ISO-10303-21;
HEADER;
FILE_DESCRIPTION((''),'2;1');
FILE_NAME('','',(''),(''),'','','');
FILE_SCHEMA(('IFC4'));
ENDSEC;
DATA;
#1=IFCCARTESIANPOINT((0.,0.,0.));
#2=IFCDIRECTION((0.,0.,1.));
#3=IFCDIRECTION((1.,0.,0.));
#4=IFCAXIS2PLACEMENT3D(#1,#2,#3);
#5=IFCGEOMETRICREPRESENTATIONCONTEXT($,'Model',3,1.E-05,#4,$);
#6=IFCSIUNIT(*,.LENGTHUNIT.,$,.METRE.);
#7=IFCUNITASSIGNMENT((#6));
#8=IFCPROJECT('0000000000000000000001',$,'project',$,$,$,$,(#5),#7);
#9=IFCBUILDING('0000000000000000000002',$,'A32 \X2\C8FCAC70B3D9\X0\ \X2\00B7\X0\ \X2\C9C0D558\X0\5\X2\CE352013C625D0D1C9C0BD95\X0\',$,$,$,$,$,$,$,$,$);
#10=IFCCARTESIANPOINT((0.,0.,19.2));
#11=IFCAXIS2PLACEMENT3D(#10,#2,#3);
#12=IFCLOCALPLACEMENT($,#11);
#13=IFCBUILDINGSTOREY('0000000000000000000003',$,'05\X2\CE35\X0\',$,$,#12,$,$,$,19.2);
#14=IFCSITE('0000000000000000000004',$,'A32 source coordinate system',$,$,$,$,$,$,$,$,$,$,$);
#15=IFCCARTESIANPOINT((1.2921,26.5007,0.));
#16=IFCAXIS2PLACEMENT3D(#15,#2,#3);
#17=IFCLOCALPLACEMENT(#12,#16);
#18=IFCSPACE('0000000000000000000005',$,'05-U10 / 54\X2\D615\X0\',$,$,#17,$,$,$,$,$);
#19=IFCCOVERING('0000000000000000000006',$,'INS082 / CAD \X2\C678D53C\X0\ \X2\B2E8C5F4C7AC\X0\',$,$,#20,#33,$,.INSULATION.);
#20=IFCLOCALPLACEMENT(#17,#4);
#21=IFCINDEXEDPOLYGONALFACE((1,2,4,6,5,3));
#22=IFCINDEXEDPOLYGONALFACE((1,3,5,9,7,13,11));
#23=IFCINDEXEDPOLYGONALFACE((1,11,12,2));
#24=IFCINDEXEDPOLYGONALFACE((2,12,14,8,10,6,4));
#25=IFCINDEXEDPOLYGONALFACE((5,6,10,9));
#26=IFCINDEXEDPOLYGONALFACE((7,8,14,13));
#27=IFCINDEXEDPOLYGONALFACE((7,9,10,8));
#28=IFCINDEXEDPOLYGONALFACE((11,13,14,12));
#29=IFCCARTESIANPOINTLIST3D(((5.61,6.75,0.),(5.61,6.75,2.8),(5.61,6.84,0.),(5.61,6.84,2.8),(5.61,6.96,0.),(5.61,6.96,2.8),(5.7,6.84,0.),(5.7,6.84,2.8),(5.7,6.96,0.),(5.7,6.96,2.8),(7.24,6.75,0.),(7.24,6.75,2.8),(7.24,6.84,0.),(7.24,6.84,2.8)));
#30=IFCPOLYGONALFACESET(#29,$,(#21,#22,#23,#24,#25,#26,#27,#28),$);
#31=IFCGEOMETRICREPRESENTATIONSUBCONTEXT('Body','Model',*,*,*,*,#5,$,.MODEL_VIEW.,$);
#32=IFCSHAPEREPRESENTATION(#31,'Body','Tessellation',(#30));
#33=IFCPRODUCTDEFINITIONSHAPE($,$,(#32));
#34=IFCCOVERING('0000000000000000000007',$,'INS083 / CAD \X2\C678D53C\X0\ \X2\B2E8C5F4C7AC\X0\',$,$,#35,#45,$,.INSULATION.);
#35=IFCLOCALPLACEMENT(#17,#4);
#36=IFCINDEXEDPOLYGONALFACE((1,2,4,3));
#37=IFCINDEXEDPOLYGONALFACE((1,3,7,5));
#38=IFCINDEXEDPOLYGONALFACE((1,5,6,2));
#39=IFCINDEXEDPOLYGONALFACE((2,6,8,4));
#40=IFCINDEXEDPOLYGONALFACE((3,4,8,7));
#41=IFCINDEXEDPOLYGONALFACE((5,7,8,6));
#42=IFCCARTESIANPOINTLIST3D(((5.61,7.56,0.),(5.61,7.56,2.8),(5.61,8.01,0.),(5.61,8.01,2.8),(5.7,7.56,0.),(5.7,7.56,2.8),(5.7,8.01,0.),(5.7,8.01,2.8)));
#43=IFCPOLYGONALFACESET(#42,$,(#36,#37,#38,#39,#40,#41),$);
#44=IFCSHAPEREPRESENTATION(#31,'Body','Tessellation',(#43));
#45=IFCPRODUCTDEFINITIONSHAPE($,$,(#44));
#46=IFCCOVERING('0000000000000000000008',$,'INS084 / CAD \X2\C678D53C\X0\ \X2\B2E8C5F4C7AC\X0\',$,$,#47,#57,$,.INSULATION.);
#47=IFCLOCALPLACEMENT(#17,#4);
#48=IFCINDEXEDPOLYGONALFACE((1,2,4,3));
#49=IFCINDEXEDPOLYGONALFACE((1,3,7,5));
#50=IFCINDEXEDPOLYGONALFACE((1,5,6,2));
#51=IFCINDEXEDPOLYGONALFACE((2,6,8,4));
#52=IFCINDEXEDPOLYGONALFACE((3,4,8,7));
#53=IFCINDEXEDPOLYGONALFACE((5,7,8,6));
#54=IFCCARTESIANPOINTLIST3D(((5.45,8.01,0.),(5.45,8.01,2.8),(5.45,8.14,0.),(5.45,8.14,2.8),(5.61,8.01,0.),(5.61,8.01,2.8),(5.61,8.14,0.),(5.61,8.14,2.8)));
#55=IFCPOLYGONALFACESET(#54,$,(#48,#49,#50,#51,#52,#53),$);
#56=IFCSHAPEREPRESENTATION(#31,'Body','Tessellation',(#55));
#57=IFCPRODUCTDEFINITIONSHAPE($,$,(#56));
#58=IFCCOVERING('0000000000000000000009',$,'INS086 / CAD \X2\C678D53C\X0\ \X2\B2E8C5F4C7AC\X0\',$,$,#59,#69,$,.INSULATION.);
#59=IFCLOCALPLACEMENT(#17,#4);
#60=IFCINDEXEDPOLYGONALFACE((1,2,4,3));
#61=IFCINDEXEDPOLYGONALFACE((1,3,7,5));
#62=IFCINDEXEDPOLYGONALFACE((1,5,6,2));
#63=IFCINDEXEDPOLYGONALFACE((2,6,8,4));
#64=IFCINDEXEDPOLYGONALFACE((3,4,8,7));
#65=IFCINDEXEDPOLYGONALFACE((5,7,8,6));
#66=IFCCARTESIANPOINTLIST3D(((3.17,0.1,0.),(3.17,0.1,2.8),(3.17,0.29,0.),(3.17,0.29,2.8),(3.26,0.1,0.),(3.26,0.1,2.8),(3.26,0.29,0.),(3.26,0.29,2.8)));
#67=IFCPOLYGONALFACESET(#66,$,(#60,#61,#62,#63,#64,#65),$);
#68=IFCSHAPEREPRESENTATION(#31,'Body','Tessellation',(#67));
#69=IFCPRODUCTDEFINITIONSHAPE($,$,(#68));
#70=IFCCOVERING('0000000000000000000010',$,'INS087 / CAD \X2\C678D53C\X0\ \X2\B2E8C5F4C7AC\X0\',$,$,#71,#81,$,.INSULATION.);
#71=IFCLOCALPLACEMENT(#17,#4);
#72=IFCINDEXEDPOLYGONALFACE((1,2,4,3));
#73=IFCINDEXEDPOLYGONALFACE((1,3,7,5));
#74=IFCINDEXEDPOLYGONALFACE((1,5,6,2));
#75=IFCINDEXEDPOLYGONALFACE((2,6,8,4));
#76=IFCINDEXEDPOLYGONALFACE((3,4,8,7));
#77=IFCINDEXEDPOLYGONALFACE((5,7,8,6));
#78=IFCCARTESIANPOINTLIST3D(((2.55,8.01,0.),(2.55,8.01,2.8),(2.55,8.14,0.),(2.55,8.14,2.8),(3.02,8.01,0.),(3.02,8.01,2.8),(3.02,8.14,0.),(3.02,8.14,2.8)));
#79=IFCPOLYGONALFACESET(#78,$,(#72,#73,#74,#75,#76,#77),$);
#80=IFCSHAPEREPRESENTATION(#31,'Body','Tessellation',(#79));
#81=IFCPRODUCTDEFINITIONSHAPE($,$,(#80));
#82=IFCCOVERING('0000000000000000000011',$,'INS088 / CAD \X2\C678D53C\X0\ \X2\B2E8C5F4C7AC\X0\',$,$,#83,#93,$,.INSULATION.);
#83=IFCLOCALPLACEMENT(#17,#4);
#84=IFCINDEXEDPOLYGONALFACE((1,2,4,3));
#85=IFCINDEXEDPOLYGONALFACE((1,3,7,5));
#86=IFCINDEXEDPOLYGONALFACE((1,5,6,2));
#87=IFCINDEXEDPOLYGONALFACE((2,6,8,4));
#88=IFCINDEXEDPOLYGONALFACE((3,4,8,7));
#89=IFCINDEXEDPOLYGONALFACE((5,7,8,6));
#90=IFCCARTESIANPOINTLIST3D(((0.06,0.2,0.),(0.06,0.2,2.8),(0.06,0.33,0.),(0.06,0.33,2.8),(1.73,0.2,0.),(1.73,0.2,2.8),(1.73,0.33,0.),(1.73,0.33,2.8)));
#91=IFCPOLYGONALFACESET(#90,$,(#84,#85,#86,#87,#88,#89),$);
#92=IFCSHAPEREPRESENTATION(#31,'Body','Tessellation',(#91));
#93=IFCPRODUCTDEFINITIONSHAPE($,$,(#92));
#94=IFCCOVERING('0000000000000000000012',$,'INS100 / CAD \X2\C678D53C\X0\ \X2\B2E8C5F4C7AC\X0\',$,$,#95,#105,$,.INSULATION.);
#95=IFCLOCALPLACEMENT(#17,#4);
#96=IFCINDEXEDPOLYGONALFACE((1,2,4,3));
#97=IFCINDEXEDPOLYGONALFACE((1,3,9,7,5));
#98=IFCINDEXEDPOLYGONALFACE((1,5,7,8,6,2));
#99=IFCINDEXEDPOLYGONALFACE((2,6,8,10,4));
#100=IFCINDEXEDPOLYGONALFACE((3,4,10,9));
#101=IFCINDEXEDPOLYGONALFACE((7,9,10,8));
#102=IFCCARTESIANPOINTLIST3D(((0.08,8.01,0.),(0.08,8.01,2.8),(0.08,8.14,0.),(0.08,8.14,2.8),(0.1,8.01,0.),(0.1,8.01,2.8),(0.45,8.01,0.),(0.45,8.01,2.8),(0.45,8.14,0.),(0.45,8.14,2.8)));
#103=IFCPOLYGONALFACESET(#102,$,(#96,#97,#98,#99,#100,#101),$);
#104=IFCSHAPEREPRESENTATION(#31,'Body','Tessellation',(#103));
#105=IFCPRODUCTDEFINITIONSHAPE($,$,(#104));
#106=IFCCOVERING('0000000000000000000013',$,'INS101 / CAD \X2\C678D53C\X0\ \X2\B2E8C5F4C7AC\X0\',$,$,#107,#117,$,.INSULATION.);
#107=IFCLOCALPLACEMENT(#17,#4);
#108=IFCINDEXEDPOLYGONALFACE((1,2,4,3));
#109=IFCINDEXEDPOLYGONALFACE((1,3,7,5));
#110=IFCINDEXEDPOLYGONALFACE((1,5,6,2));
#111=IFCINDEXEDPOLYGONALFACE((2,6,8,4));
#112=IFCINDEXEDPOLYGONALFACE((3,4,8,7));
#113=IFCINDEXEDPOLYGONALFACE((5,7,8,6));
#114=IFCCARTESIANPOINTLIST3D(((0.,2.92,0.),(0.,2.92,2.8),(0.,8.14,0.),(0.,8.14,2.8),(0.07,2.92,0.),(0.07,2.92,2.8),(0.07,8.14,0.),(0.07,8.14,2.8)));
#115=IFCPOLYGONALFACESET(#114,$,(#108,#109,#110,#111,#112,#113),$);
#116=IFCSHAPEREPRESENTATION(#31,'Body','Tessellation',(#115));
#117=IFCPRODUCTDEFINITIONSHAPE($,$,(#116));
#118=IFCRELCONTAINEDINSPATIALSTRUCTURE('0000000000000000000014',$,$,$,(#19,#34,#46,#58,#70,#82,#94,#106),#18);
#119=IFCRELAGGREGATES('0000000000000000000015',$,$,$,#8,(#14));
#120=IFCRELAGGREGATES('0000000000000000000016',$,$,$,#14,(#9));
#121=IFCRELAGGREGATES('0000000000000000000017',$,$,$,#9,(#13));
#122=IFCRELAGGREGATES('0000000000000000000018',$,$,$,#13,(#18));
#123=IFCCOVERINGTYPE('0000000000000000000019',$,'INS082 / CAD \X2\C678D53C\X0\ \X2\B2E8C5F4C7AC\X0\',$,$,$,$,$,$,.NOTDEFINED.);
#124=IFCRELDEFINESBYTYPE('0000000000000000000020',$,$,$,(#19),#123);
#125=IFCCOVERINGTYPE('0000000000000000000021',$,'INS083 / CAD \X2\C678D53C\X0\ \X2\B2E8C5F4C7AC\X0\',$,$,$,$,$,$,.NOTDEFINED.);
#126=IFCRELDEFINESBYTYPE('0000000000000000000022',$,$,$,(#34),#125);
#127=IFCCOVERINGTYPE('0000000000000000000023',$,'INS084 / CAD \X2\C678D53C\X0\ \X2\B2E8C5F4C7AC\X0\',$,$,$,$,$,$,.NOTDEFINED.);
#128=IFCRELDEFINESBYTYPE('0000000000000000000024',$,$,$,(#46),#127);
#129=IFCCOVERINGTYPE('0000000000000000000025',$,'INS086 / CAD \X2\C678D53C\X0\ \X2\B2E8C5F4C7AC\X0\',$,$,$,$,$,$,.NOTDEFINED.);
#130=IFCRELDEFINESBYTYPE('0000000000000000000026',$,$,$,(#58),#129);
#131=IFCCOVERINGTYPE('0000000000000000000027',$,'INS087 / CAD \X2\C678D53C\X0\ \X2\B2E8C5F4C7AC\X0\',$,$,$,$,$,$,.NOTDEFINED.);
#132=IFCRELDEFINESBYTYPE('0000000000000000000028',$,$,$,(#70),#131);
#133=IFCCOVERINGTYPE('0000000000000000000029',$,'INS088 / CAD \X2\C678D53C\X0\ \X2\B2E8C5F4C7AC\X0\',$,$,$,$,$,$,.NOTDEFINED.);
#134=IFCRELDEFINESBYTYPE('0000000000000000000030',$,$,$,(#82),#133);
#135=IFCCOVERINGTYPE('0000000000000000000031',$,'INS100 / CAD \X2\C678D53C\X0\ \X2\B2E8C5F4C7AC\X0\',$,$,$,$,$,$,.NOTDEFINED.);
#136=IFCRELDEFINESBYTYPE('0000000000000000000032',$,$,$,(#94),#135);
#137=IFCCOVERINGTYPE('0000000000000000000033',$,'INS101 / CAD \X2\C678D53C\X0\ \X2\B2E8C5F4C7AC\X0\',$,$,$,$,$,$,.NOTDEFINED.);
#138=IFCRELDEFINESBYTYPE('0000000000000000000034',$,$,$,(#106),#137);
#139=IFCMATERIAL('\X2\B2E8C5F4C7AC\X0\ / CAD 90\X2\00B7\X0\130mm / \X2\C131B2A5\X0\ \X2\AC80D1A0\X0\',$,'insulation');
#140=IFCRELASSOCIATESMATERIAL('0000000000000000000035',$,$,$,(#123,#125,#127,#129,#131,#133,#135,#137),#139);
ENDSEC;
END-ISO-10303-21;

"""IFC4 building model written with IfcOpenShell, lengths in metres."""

from ifc_helpers import new_model, si_unit, frame, origin, origin_with_axes, place, context, subcontext, project, spatial, polyline, outline, extrude, source, transform, mapped, material, type_object, type_shapes, element, save


model = new_model("IFC4")

# Units and contexts
model_context = context("Model", 3, precision=1e-05, world=origin_with_axes())
body_context = subcontext(model_context, "Body", "Model", "MODEL_VIEW")
ifc_project = project(units=[si_unit("LENGTHUNIT", "METRE")], contexts=[model_context])

# Site, building, storey, space
storey_placement = place(None, frame((0.0, 0.0, 19.2), z_axis=(0.0, 0.0, 1.0), x_axis=(1.0, 0.0, 0.0)))
space_placement = place(storey_placement, frame((1.2921, 26.5007, 0.0), z_axis=(0.0, 0.0, 1.0), x_axis=(1.0, 0.0, 0.0)))
site = spatial("IfcSite", under=ifc_project, Name="A32 source coordinate system")
building = spatial("IfcBuilding", under=site, Name="A32 주거동 · 지하5층–옥탑지붕")
storey = spatial("IfcBuildingStorey", under=building, at=storey_placement, Name="05층", Elevation=19.2)
space = spatial("IfcSpace", under=storey, at=space_placement, Name="05-U10 / 54형")

# Coverings
ifc_material = material(Name="단열재 / CAD 90·130mm / 성능 검토", Category="insulation")
covering_type_1 = type_object("IfcCoveringType", Name="INS082 / CAD 외피 단열재", PredefinedType="NOTDEFINED", material=ifc_material)
shared_shape_1 = source(origin(), body_context, "Body", "SweptSolid", [
    extrude(outline(polyline([(5.61, 6.84), (5.61, 6.96), (5.7, 6.96), (5.7, 6.84), (7.24, 6.84), (7.24, 6.75), (5.61, 6.75), (5.61, 6.84)])), origin(), (0.0, 0.0, 1.0), 2.8),
])
type_shapes(covering_type_1, [shared_shape_1])
covering_1_placement = place(space_placement, origin_with_axes())
element("IfcCovering", 1, at=covering_1_placement, inside=space, type_object=covering_type_1, Name="INS082 / CAD 외피 단열재", PredefinedType="INSULATION", context=body_context, shape_type="MappedRepresentation", body=[
    mapped(shared_shape_1, transform((0.0, 0.0, 0.0), scale=1.0)),
])
covering_type_2 = type_object("IfcCoveringType", Name="INS083 / CAD 외피 단열재", PredefinedType="NOTDEFINED", material=ifc_material)
shared_shape_2 = source(origin(), body_context, "Body", "SweptSolid", [
    extrude(outline(polyline([(5.61, 8.01), (5.7, 8.01), (5.7, 7.56), (5.61, 7.56), (5.61, 8.01)])), origin(), (0.0, 0.0, 1.0), 2.8),
])
type_shapes(covering_type_2, [shared_shape_2])
covering_2_placement = place(space_placement, origin_with_axes())
element("IfcCovering", 2, at=covering_2_placement, inside=space, type_object=covering_type_2, Name="INS083 / CAD 외피 단열재", PredefinedType="INSULATION", context=body_context, shape_type="MappedRepresentation", body=[
    mapped(shared_shape_2, transform((0.0, 0.0, 0.0), scale=1.0)),
])
covering_type_3 = type_object("IfcCoveringType", Name="INS084 / CAD 외피 단열재", PredefinedType="NOTDEFINED", material=ifc_material)
shared_shape_3 = source(origin(), body_context, "Body", "SweptSolid", [
    extrude(outline(polyline([(5.45, 8.01), (5.45, 8.14), (5.61, 8.14), (5.61, 8.01), (5.45, 8.01)])), origin(), (0.0, 0.0, 1.0), 2.8),
])
type_shapes(covering_type_3, [shared_shape_3])
covering_3_placement = place(space_placement, origin_with_axes())
element("IfcCovering", 3, at=covering_3_placement, inside=space, type_object=covering_type_3, Name="INS084 / CAD 외피 단열재", PredefinedType="INSULATION", context=body_context, shape_type="MappedRepresentation", body=[
    mapped(shared_shape_3, transform((0.0, 0.0, 0.0), scale=1.0)),
])
covering_type_4 = type_object("IfcCoveringType", Name="INS086 / CAD 외피 단열재", PredefinedType="NOTDEFINED", material=ifc_material)
shared_shape_4 = source(origin(), body_context, "Body", "SweptSolid", [
    extrude(outline(polyline([(3.17, 0.1), (3.17, 0.29), (3.26, 0.29), (3.26, 0.1), (3.17, 0.1)])), origin(), (0.0, 0.0, 1.0), 2.8),
])
type_shapes(covering_type_4, [shared_shape_4])
covering_4_placement = place(space_placement, origin_with_axes())
element("IfcCovering", 4, at=covering_4_placement, inside=space, type_object=covering_type_4, Name="INS086 / CAD 외피 단열재", PredefinedType="INSULATION", context=body_context, shape_type="MappedRepresentation", body=[
    mapped(shared_shape_4, transform((0.0, 0.0, 0.0), scale=1.0)),
])
covering_type_5 = type_object("IfcCoveringType", Name="INS087 / CAD 외피 단열재", PredefinedType="NOTDEFINED", material=ifc_material)
shared_shape_5 = source(origin(), body_context, "Body", "SweptSolid", [
    extrude(outline(polyline([(2.55, 8.14), (3.02, 8.14), (3.02, 8.01), (2.55, 8.01), (2.55, 8.14)])), origin(), (0.0, 0.0, 1.0), 2.8),
])
type_shapes(covering_type_5, [shared_shape_5])
covering_5_placement = place(space_placement, origin_with_axes())
element("IfcCovering", 5, at=covering_5_placement, inside=space, type_object=covering_type_5, Name="INS087 / CAD 외피 단열재", PredefinedType="INSULATION", context=body_context, shape_type="MappedRepresentation", body=[
    mapped(shared_shape_5, transform((0.0, 0.0, 0.0), scale=1.0)),
])
covering_type_6 = type_object("IfcCoveringType", Name="INS088 / CAD 외피 단열재", PredefinedType="NOTDEFINED", material=ifc_material)
shared_shape_6 = source(origin(), body_context, "Body", "SweptSolid", [
    extrude(outline(polyline([(0.06, 0.33), (1.73, 0.33), (1.73, 0.2), (0.06, 0.2), (0.06, 0.33)])), origin(), (0.0, 0.0, 1.0), 2.8),
])
type_shapes(covering_type_6, [shared_shape_6])
covering_6_placement = place(space_placement, origin_with_axes())
element("IfcCovering", 6, at=covering_6_placement, inside=space, type_object=covering_type_6, Name="INS088 / CAD 외피 단열재", PredefinedType="INSULATION", context=body_context, shape_type="MappedRepresentation", body=[
    mapped(shared_shape_6, transform((0.0, 0.0, 0.0), scale=1.0)),
])
covering_type_7 = type_object("IfcCoveringType", Name="INS100 / CAD 외피 단열재", PredefinedType="NOTDEFINED", material=ifc_material)
shared_shape_7 = source(origin(), body_context, "Body", "SweptSolid", [
    extrude(outline(polyline([(0.08, 8.01), (0.08, 8.14), (0.45, 8.14), (0.45, 8.01), (0.1, 8.01), (0.08, 8.01)])), origin(), (0.0, 0.0, 1.0), 2.8),
])
type_shapes(covering_type_7, [shared_shape_7])
covering_7_placement = place(space_placement, origin_with_axes())
element("IfcCovering", 7, at=covering_7_placement, inside=space, type_object=covering_type_7, Name="INS100 / CAD 외피 단열재", PredefinedType="INSULATION", context=body_context, shape_type="MappedRepresentation", body=[
    mapped(shared_shape_7, transform((0.0, 0.0, 0.0), scale=1.0)),
])
covering_type_8 = type_object("IfcCoveringType", Name="INS101 / CAD 외피 단열재", PredefinedType="NOTDEFINED", material=ifc_material)
shared_shape_8 = source(origin(), body_context, "Body", "SweptSolid", [
    extrude(outline(polyline([(0.0, 2.92), (0.0, 8.14), (0.07, 8.14), (0.07, 2.92), (0.0, 2.92)])), origin(), (0.0, 0.0, 1.0), 2.8),
])
type_shapes(covering_type_8, [shared_shape_8])
covering_8_placement = place(space_placement, origin_with_axes())
element("IfcCovering", 8, at=covering_8_placement, inside=space, type_object=covering_type_8, Name="INS101 / CAD 외피 단열재", PredefinedType="INSULATION", context=body_context, shape_type="MappedRepresentation", body=[
    mapped(shared_shape_8, transform((0.0, 0.0, 0.0), scale=1.0)),
])

save(model, "model.ifc")
